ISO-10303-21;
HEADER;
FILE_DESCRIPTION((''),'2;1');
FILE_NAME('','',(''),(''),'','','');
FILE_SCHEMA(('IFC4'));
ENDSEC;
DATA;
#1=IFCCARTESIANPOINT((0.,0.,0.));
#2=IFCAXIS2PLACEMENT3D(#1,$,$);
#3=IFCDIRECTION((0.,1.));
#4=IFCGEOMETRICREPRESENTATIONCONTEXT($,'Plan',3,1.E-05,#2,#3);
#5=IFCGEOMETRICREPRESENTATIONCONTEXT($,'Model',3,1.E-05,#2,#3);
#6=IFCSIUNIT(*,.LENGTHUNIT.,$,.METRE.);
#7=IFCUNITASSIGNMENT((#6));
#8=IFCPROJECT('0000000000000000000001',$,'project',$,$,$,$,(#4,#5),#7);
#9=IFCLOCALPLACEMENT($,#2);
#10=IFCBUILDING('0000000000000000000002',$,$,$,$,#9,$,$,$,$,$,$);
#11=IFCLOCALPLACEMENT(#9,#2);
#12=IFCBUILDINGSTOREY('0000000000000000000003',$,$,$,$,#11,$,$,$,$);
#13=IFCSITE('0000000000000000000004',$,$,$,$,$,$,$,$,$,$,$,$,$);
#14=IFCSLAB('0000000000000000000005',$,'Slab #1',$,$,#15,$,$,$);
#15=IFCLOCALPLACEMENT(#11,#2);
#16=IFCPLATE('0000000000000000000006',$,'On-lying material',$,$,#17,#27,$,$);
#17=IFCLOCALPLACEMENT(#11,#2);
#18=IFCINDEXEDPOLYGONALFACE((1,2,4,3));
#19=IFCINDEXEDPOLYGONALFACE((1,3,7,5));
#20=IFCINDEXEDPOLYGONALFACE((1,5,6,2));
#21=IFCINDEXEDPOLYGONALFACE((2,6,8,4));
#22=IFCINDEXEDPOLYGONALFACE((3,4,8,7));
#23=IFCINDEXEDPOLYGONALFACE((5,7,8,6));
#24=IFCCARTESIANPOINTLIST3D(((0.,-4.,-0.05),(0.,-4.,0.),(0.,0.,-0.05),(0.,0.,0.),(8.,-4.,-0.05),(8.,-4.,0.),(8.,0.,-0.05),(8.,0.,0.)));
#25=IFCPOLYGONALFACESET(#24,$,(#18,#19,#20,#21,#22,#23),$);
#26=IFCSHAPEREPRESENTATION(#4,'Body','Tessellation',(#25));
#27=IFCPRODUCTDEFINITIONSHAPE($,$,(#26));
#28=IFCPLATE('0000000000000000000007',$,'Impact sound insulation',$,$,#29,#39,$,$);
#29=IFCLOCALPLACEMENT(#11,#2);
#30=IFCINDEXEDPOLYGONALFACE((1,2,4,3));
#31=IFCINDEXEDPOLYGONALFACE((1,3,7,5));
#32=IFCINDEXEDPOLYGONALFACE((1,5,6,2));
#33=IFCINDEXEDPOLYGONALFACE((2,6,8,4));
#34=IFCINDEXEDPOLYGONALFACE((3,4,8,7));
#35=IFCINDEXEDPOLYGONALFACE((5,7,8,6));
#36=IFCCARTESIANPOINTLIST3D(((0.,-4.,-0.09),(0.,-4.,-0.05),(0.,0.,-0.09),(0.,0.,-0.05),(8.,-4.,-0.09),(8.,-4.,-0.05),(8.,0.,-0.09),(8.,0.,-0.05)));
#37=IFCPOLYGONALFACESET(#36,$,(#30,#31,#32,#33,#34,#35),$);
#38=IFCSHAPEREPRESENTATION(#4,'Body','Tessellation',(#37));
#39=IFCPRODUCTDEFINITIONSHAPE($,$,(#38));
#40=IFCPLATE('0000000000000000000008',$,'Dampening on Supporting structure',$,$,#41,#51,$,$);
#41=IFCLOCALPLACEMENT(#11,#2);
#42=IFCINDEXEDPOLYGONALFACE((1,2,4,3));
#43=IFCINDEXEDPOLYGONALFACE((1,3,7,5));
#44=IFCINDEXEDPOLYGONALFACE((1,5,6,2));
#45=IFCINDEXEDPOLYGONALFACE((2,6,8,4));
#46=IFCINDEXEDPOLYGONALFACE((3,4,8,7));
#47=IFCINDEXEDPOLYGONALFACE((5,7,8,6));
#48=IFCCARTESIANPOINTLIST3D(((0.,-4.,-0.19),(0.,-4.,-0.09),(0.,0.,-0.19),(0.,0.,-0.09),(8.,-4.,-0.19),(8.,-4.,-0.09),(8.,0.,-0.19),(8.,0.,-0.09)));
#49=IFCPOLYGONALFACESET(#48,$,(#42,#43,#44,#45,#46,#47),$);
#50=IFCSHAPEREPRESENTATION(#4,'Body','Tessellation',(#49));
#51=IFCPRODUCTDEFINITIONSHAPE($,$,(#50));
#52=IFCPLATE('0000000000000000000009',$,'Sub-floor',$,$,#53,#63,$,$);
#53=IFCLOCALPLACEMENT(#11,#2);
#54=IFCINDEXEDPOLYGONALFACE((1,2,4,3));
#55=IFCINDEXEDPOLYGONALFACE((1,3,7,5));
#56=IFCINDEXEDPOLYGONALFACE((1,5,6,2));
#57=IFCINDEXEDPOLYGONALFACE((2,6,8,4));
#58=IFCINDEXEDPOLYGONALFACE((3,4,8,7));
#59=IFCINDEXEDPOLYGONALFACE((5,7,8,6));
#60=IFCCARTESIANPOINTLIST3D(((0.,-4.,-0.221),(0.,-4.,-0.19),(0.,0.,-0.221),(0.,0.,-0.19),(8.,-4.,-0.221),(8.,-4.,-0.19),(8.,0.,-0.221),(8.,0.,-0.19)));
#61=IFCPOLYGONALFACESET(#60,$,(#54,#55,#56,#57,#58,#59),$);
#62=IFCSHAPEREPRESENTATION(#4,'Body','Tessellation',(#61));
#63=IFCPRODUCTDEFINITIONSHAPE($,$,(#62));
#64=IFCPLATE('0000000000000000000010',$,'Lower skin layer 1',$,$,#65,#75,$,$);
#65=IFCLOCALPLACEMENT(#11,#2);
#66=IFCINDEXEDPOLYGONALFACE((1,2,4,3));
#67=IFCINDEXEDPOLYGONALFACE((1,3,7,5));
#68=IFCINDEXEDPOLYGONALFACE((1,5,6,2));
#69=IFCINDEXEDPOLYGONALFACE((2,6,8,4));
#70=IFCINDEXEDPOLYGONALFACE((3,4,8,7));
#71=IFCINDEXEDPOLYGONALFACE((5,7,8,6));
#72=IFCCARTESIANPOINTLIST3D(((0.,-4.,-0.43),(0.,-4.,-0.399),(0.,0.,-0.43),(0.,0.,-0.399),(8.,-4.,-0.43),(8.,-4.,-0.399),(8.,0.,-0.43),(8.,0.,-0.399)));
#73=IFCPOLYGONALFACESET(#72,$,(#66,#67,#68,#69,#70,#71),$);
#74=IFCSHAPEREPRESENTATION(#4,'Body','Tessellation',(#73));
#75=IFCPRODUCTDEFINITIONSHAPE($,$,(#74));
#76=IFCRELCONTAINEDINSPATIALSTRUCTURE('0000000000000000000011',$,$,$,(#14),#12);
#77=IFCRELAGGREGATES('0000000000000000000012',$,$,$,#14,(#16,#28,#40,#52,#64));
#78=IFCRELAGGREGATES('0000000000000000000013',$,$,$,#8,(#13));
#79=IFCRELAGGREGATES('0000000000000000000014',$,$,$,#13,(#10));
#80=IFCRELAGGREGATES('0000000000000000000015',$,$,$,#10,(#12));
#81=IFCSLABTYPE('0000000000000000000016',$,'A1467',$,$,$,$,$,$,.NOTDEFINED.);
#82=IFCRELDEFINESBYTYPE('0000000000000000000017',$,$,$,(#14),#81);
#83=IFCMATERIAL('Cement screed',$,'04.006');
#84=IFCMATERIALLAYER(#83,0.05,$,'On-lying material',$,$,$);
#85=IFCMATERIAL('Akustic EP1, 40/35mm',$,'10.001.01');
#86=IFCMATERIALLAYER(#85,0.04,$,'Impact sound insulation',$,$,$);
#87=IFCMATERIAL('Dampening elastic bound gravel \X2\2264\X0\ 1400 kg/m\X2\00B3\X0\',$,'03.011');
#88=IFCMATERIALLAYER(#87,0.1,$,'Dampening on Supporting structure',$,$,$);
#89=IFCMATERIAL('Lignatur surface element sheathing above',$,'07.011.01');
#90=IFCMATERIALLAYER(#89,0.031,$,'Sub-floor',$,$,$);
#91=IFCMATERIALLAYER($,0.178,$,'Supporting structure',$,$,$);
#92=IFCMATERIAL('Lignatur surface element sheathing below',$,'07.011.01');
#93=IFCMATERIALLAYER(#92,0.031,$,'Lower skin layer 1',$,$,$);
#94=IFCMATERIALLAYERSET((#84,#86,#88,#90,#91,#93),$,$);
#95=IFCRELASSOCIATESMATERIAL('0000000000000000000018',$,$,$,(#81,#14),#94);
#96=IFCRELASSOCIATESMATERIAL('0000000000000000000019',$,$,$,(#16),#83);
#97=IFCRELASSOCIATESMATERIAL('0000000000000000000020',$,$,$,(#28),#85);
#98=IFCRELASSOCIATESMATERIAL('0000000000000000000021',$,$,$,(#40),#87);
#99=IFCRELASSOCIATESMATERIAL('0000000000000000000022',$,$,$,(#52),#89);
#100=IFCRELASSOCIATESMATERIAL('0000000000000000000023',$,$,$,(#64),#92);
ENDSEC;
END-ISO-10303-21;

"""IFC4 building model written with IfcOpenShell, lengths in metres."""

from ifc_helpers import new_model, si_unit, direction, frame, frame_2d, origin, origin_with_axes, place, context, project, spatial, rectangle, extrude, material, layer, layer_set, type_object, element, aggregate, save


model = new_model("IFC4")

# Units and contexts
plan_context = context("Plan", 3, precision=1e-05, world=origin(), true_north=direction((0.0, 1.0)))
model_context = context("Model", 3, precision=1e-05, world=origin(), true_north=direction((0.0, 1.0)))
ifc_project = project(units=[si_unit("LENGTHUNIT", "METRE")], contexts=[plan_context, model_context])

# Site, building, storey
site = spatial("IfcSite", under=ifc_project)
building_placement = place(None, origin())
building = spatial("IfcBuilding", under=site, at=building_placement)
storey_placement = place(building_placement, origin())
storey = spatial("IfcBuildingStorey", under=building, at=storey_placement)

# Slab, plates
ifc_material_1 = material(Name="Cement screed", Category="04.006")
ifc_layer_1 = layer(ifc_material_1, 0.05, Name="On-lying material")
ifc_material_2 = material(Name="Akustic EP1, 40/35mm", Category="10.001.01")
ifc_layer_2 = layer(ifc_material_2, 0.04, Name="Impact sound insulation")
ifc_material_3 = material(Name="Dampening elastic bound gravel ≤ 1400 kg/m³", Category="03.011")
ifc_layer_3 = layer(ifc_material_3, 0.1, Name="Dampening on Supporting structure")
ifc_material_4 = material(Name="Lignatur surface element sheathing above", Category="07.011.01")
ifc_layer_4 = layer(ifc_material_4, 0.031, Name="Sub-floor")
ifc_layer_5 = layer(None, 0.178, Name="Supporting structure")
ifc_material_5 = material(Name="Lignatur surface element sheathing below", Category="07.011.01")
ifc_layer_6 = layer(ifc_material_5, 0.031, Name="Lower skin layer 1")
ifc_layer_set = layer_set([ifc_layer_1, ifc_layer_2, ifc_layer_3, ifc_layer_4, ifc_layer_5, ifc_layer_6])
slab_type = type_object("IfcSlabType", Name="A1467", PredefinedType="NOTDEFINED", material=ifc_layer_set)
slab_placement = place(None, frame((0.0, 0.0, 0.0), z_axis=(0.0, 0.0, -1.0), x_axis=(1.0, 0.0, 0.0)))
slab = element("IfcSlab", 1, at=slab_placement, inside=storey, type_object=slab_type, material=ifc_layer_set, Name="Slab #1")
plate_1_placement = place(slab_placement, origin())
plate_1 = element("IfcPlate", 2, at=plate_1_placement, material=ifc_material_1, Name="On-lying material", context=plan_context, shape_type="SweptSolid", body=[
    extrude(rectangle(XDim=8.0, YDim=4.0, at=frame_2d((4.0, 2.0), x_axis=(1.0, 0.0))), origin_with_axes(), (0.0, 0.0, 1.0), 0.05),
])
plate_2_placement = place(slab_placement, origin())
plate_2 = element("IfcPlate", 3, at=plate_2_placement, material=ifc_material_2, Name="Impact sound insulation", context=plan_context, shape_type="SweptSolid", body=[
    extrude(rectangle(XDim=8.0, YDim=4.0, at=frame_2d((4.0, 2.0), x_axis=(1.0, 0.0))), frame((0.0, 0.0, 0.05), z_axis=(0.0, 0.0, 1.0), x_axis=(1.0, 0.0, 0.0)), (0.0, 0.0, 1.0), 0.04),
])
plate_3_placement = place(slab_placement, origin())
plate_3 = element("IfcPlate", 4, at=plate_3_placement, material=ifc_material_3, Name="Dampening on Supporting structure", context=plan_context, shape_type="SweptSolid", body=[
    extrude(rectangle(XDim=8.0, YDim=4.0, at=frame_2d((4.0, 2.0), x_axis=(1.0, 0.0))), frame((0.0, 0.0, 0.09), z_axis=(0.0, 0.0, 1.0), x_axis=(1.0, 0.0, 0.0)), (0.0, 0.0, 1.0), 0.1),
])
plate_4_placement = place(slab_placement, origin())
plate_4 = element("IfcPlate", 5, at=plate_4_placement, material=ifc_material_4, Name="Sub-floor", context=plan_context, shape_type="SweptSolid", body=[
    extrude(rectangle(XDim=8.0, YDim=4.0, at=frame_2d((4.0, 2.0), x_axis=(1.0, 0.0))), frame((0.0, 0.0, 0.19), z_axis=(0.0, 0.0, 1.0), x_axis=(1.0, 0.0, 0.0)), (0.0, 0.0, 1.0), 0.031),
])
plate_5_placement = place(slab_placement, origin())
plate_5 = element("IfcPlate", 6, at=plate_5_placement, material=ifc_material_5, Name="Lower skin layer 1", context=plan_context, shape_type="SweptSolid", body=[
    extrude(rectangle(XDim=8.0, YDim=4.0, at=frame_2d((4.0, 2.0), x_axis=(1.0, 0.0))), frame((0.0, 0.0, 0.399), z_axis=(0.0, 0.0, 1.0), x_axis=(1.0, 0.0, 0.0)), (0.0, 0.0, 1.0), 0.031),
])
aggregate(slab, [plate_1, plate_2, plate_3, plate_4, plate_5])

save(model, "model.ifc")
